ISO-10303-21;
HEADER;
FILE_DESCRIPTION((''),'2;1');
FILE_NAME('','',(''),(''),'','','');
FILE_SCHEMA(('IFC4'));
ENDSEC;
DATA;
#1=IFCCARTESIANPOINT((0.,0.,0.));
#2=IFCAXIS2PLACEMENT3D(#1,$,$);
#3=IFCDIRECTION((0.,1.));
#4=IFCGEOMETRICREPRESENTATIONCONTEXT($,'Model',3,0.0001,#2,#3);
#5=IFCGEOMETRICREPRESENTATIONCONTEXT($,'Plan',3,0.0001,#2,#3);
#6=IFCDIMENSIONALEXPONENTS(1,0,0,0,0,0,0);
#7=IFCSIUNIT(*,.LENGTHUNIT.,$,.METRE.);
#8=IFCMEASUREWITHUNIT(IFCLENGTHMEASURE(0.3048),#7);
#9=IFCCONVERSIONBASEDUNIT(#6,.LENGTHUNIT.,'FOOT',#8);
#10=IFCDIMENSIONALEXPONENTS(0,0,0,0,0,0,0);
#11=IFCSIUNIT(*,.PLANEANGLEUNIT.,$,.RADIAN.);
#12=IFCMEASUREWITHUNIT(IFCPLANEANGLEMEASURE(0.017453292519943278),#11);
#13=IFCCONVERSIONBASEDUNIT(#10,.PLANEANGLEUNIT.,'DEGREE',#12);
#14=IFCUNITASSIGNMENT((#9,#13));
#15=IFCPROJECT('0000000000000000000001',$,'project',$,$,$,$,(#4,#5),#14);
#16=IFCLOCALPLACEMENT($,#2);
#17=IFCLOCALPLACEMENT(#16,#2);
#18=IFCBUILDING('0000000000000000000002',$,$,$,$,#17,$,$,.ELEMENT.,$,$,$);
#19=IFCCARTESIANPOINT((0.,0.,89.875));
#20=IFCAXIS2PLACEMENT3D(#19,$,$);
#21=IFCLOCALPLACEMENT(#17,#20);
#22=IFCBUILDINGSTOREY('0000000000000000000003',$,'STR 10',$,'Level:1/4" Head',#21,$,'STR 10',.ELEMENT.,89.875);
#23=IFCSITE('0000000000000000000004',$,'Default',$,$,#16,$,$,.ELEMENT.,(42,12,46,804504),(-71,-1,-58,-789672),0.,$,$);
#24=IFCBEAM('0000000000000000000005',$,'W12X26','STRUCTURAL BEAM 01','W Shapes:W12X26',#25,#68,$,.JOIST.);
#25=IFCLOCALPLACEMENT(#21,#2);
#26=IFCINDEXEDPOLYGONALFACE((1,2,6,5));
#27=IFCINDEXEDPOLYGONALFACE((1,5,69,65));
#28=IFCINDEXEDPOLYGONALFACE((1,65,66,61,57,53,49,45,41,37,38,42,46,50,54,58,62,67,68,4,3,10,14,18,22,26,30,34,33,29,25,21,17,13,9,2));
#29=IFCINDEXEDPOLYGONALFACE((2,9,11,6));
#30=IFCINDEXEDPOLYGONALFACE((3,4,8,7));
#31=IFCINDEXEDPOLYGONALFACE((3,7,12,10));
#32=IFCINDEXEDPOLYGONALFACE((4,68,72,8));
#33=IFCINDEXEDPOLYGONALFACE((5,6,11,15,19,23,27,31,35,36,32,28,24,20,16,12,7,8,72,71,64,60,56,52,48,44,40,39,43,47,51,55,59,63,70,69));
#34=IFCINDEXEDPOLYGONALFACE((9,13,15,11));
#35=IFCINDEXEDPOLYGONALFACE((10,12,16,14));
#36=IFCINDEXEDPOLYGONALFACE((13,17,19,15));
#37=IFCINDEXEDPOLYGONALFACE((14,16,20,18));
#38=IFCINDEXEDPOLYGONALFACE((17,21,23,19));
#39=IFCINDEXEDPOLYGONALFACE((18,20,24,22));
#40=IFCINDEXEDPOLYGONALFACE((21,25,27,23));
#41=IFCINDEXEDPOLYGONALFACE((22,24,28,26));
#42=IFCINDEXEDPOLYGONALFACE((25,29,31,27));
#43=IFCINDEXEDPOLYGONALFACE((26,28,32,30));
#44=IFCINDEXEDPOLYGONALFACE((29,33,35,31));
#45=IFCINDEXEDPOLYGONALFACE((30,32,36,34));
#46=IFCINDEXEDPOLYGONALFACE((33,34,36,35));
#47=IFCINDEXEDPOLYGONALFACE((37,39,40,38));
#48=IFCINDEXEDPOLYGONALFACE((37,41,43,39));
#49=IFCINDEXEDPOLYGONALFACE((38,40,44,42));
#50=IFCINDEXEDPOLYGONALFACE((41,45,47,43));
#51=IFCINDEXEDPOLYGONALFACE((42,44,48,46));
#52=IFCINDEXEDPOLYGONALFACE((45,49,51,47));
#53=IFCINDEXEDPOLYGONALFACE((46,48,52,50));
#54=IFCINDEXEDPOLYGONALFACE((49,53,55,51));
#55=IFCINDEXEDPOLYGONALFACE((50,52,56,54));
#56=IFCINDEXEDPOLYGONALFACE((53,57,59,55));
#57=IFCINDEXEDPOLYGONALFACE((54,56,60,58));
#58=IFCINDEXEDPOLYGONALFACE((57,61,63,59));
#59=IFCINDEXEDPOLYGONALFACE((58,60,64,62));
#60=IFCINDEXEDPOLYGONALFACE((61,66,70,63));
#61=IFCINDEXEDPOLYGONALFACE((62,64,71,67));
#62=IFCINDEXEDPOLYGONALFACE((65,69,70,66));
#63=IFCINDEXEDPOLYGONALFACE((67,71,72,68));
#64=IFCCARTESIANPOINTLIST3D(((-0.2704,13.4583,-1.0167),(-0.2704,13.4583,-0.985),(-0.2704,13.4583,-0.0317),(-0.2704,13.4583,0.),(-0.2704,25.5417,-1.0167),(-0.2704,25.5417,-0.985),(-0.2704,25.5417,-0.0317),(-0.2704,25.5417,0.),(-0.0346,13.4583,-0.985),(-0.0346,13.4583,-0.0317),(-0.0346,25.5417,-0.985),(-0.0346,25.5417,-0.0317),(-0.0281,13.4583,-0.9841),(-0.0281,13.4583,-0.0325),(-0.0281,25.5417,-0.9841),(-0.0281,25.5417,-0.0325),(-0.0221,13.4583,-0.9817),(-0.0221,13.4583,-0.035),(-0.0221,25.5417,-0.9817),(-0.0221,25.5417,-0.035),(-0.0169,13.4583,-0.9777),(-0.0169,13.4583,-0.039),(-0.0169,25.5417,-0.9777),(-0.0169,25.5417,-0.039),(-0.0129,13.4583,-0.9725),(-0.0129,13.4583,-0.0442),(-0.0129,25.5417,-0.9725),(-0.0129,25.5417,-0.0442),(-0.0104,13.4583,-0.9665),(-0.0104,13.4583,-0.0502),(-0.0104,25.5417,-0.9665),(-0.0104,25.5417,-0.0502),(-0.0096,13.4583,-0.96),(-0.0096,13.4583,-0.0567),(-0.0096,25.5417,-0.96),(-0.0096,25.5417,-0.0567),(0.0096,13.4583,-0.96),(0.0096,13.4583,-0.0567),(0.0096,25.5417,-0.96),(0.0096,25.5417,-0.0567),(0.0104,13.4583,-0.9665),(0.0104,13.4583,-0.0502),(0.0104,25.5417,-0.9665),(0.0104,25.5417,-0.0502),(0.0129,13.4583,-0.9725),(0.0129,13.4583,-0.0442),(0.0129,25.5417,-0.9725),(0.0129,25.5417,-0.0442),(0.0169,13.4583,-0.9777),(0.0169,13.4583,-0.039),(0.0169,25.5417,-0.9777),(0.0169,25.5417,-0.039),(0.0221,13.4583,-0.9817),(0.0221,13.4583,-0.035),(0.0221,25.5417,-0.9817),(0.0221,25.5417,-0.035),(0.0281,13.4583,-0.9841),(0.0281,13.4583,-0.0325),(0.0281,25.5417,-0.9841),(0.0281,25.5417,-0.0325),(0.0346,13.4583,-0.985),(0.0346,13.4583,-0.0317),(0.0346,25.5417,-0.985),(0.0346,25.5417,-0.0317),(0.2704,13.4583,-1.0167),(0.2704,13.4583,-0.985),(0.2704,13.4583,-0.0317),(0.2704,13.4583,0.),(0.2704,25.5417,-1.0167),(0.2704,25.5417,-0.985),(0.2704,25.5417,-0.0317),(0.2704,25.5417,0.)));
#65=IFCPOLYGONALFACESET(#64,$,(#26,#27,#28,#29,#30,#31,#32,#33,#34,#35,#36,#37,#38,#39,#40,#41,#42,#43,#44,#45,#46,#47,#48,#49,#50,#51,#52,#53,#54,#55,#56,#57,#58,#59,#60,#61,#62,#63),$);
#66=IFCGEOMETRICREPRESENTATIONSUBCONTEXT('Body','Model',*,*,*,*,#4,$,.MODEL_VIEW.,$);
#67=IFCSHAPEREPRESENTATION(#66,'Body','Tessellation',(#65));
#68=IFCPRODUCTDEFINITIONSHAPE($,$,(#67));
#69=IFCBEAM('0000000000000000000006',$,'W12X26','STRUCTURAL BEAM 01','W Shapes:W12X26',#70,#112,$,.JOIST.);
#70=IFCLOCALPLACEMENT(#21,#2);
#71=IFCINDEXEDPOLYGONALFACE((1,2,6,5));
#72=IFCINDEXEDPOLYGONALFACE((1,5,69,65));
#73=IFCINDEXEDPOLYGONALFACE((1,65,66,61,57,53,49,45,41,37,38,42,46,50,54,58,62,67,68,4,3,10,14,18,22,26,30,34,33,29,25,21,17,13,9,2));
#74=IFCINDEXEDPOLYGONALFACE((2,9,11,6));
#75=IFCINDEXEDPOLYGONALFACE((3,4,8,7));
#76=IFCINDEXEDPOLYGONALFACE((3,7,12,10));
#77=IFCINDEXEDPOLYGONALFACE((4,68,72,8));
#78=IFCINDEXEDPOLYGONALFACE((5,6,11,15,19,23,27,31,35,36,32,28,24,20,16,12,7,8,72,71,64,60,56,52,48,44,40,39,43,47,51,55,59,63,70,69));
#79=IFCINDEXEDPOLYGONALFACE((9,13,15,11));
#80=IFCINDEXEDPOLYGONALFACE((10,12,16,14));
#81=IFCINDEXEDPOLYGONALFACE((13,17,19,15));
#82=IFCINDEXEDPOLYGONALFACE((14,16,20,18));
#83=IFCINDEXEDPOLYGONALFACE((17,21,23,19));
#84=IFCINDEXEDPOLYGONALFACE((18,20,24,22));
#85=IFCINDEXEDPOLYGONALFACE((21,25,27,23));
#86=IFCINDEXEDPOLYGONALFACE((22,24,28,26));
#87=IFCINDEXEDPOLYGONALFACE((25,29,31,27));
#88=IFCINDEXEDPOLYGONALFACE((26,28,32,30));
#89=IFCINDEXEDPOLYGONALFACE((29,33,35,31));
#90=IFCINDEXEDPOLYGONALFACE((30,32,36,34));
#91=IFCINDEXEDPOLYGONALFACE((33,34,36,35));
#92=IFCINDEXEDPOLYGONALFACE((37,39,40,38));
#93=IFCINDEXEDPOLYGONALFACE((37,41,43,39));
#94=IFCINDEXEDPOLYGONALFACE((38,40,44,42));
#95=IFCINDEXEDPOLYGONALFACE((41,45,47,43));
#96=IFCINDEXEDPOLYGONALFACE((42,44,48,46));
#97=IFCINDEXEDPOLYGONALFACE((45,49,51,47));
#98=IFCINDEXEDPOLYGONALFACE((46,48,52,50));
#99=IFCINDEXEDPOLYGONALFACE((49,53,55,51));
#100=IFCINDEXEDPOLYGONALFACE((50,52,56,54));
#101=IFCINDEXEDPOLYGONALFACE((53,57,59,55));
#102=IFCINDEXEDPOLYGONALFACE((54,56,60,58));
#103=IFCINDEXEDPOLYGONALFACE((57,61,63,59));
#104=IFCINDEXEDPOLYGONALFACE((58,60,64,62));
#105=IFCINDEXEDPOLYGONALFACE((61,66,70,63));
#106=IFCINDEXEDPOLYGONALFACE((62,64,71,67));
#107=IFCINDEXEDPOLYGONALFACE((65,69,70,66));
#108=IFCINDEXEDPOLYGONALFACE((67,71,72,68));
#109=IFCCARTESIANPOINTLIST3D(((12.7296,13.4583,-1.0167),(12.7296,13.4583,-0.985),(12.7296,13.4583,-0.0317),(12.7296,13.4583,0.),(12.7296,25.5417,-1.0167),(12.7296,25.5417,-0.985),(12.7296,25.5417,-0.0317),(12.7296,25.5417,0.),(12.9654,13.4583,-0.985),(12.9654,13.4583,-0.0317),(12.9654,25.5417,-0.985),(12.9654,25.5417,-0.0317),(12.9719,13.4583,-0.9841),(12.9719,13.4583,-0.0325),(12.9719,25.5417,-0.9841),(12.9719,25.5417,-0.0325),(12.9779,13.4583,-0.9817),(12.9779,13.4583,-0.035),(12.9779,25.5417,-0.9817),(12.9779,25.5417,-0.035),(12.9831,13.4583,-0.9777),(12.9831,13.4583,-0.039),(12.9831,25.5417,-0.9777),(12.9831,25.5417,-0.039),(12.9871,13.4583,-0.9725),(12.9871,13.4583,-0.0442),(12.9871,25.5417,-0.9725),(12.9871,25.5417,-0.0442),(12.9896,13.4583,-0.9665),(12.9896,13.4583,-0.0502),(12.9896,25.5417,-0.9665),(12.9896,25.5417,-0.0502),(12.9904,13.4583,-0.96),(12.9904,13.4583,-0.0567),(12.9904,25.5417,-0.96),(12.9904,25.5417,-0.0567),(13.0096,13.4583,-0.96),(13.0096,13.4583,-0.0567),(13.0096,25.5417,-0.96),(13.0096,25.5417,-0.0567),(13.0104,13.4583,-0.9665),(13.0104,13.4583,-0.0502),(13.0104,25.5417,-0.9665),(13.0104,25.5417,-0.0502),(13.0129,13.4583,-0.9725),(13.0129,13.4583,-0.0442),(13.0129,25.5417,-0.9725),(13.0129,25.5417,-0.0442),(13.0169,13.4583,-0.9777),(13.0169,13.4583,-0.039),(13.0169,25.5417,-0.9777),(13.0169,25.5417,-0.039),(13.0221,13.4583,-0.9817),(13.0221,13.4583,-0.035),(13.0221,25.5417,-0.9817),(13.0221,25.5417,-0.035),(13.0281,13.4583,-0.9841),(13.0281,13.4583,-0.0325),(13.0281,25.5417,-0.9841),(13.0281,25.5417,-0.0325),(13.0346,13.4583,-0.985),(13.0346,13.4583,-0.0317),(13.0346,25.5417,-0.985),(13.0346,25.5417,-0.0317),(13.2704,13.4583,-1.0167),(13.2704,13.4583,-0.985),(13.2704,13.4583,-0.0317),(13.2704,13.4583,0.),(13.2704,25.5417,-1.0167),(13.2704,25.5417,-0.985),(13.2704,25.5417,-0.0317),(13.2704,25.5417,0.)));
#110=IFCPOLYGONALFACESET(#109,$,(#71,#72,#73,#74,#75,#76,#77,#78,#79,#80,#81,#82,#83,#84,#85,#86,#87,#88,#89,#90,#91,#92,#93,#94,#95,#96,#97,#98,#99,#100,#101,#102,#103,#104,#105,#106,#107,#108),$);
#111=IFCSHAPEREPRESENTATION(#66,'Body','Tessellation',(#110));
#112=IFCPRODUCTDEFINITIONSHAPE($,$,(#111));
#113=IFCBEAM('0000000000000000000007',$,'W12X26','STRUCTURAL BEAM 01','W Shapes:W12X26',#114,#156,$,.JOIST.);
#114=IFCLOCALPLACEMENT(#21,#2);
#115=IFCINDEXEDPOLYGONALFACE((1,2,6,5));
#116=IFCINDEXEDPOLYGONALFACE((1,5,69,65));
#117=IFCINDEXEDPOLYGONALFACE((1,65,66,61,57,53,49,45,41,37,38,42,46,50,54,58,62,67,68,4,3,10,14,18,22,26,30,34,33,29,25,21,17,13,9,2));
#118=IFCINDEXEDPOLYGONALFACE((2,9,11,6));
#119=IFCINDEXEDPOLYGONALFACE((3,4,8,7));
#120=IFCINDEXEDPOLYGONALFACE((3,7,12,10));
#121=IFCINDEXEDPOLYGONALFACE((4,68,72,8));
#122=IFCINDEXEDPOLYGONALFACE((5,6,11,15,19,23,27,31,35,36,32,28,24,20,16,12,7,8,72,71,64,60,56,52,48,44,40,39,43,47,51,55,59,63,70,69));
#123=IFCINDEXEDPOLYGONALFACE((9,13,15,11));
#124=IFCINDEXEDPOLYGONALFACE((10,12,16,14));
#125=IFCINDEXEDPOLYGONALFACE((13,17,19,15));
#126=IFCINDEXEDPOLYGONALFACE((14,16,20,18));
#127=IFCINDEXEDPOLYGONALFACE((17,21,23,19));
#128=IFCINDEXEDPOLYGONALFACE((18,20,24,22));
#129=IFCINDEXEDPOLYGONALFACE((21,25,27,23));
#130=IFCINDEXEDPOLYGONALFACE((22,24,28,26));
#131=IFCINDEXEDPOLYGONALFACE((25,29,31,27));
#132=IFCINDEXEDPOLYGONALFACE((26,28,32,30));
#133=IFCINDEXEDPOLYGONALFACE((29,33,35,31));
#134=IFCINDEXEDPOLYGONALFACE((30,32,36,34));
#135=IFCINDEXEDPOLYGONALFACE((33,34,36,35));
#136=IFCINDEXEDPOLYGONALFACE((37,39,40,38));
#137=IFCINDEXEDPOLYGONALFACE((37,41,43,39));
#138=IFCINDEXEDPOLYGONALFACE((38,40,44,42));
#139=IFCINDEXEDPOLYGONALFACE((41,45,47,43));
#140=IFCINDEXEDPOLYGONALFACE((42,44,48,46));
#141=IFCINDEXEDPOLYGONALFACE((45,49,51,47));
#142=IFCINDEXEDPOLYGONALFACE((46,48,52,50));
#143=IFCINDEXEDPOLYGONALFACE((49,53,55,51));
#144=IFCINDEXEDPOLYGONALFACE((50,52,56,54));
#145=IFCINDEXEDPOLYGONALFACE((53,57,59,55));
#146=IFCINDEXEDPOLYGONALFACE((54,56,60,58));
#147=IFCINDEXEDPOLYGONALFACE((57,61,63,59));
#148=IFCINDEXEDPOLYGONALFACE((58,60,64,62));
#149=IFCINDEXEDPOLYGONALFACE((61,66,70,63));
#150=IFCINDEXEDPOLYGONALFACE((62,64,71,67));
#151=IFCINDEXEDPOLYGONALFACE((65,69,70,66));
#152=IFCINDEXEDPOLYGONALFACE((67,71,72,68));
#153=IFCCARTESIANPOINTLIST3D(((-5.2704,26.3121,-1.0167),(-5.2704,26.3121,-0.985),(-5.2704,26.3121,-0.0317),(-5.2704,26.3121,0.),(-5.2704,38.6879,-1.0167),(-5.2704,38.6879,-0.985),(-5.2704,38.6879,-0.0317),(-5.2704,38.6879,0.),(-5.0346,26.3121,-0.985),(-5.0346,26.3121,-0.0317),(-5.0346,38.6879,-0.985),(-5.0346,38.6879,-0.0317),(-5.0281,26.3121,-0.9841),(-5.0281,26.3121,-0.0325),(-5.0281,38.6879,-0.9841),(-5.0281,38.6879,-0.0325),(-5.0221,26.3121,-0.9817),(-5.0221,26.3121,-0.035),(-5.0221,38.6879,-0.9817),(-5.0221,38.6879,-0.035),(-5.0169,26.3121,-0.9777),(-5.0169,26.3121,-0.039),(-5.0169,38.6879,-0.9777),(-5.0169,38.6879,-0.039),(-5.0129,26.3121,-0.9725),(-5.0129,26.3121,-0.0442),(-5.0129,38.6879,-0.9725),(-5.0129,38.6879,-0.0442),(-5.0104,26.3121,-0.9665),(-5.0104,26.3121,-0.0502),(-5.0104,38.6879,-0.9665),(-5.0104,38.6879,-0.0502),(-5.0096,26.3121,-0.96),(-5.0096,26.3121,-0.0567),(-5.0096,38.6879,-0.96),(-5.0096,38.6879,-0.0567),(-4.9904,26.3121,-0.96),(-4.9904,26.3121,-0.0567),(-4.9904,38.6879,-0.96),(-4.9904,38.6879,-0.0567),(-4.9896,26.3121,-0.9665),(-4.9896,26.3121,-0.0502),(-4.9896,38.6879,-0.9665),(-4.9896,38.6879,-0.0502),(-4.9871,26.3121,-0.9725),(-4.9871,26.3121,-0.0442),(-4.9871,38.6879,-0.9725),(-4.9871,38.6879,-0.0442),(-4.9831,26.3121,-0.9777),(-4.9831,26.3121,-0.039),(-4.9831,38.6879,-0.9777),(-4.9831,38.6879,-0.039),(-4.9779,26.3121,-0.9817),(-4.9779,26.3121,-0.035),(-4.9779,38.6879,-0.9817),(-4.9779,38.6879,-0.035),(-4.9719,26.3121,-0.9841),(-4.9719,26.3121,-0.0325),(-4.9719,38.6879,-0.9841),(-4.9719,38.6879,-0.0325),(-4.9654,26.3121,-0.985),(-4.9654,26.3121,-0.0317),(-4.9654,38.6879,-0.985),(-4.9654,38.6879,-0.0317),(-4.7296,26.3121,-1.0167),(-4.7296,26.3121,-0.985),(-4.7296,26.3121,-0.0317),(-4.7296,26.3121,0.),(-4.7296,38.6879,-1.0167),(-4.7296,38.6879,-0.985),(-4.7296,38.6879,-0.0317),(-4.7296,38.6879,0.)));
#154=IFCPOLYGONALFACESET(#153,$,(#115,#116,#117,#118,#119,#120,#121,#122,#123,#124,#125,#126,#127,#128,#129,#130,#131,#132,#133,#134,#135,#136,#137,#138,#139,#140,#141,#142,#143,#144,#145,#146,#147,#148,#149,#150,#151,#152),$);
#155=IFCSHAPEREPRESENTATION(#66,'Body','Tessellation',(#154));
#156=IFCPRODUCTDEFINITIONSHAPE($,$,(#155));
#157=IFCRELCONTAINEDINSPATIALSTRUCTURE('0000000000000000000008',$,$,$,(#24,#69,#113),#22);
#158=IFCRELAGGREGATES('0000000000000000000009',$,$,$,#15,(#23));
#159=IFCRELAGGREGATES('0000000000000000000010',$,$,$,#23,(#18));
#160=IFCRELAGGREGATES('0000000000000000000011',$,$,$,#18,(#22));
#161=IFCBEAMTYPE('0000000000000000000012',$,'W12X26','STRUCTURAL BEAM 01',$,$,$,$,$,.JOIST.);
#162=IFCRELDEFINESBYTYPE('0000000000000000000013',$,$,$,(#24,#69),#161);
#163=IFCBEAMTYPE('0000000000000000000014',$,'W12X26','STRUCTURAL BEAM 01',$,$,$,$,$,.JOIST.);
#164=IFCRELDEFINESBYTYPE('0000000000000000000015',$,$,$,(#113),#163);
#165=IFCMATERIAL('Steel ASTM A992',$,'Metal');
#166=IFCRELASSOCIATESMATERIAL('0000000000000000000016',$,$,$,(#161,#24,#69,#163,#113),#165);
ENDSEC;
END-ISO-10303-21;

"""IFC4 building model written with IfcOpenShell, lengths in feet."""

from ifc_helpers import new_model, entity, si_unit, converted_unit, direction, frame, origin, place, context, subcontext, project, spatial, line, arc, indexed_curve, outline, extrude, source, transform, mapped, material, type_object, type_shapes, element, save


model = new_model("IFC4")

# Units and contexts
model_context = context("Model", 3, precision=0.0001, world=origin(), true_north=direction((0.0, 1.0)))
plan_context = context("Plan", 3, precision=0.0001, world=origin(), true_north=direction((0.0, 1.0)))
body_context = subcontext(model_context, "Body", "Model", "MODEL_VIEW")
ifc_project = project(units=[converted_unit("LENGTHUNIT", "FOOT", entity("IfcLengthMeasure", 0.3048), si_unit("LENGTHUNIT", "METRE"), dimensions=[1, 0, 0, 0, 0, 0, 0]), converted_unit("PLANEANGLEUNIT", "DEGREE", entity("IfcPlaneAngleMeasure", 0.017453292519943278), si_unit("PLANEANGLEUNIT", "RADIAN"), dimensions=[0, 0, 0, 0, 0, 0, 0])], contexts=[model_context, plan_context])

# Site, building, storey
site_placement = place(None, origin())
site = spatial("IfcSite", under=ifc_project, at=site_placement, Name="Default", CompositionType="ELEMENT", RefLatitude=(42, 12, 46, 804504), RefLongitude=(-71, -1, -58, -789672), RefElevation=0.0)
building_placement = place(site_placement, origin())
building = spatial("IfcBuilding", under=site, at=building_placement, CompositionType="ELEMENT")
storey_placement = place(building_placement, frame((0.0, 0.0, 89.875)))
storey = spatial("IfcBuildingStorey", under=building, at=storey_placement, Name="STR 10", ObjectType="Level:1/4\" Head", LongName="STR 10", CompositionType="ELEMENT", Elevation=89.875)

# Beams
ifc_material = material(Name="Steel ASTM A992", Category="Metal")
beam_type_1 = type_object("IfcBeamType", Name="W12X26", Description="STRUCTURAL BEAM 01", PredefinedType="JOIST", material=ifc_material)
shared_shape_1 = source(origin(), body_context, "Body", "SweptSolid", [
    extrude(outline(indexed_curve([(-0.2704, -0.4767), (-0.2704, -0.5083), (0.2704, -0.5083), (0.2704, -0.4767), (0.0346, -0.4767), (0.0169, -0.4693), (0.0096, -0.4517), (0.0096, 0.4517), (0.0169, 0.4693), (0.0346, 0.4767), (0.2704, 0.4767), (0.2704, 0.5083), (-0.2704, 0.5083), (-0.2704, 0.4767), (-0.0346, 0.4767), (-0.0169, 0.4693), (-0.0096, 0.4517), (-0.0096, -0.4517), (-0.0169, -0.4693), (-0.0346, -0.4767)], segments=[line(1, 2, 3, 4, 5), arc(5, 6, 7), line(7, 8), arc(8, 9, 10), line(10, 11, 12, 13, 14, 15), arc(15, 16, 17), line(17, 18), arc(18, 19, 20), line(20, 1)], self_intersect=False)), frame((-6.2267, 0.0, 0.0), z_axis=(-1.0, 0.0, 0.0), x_axis=(0.0, -1.0, 0.0)), (0.0, 0.0, -1.0), 12.0833),
])
type_shapes(beam_type_1, [shared_shape_1])
for number, where, z_axis, x_axis, name in (
    (1, (0.0, 19.685, -0.5083), (0.0, 0.0, 1.0), (0.0, 1.0, 0.0), "W12X26"),
    (2, (13.0, 19.685, -0.5083), (0.0, 0.0, 1.0), (0.0, 1.0, 0.0), "W12X26"),
):
    element("IfcBeam", number, at=place(storey_placement, frame(where, z_axis=z_axis, x_axis=x_axis)), inside=storey, type_object=beam_type_1, material=ifc_material, Name=name, Description="STRUCTURAL BEAM 01", ObjectType="W Shapes:W12X26", PredefinedType="JOIST", context=body_context, shape_type="MappedRepresentation", body=[
        mapped(shared_shape_1, transform((0.0, 0.0, 0.0), scale=1.0)),
    ])
beam_type_2 = type_object("IfcBeamType", Name="W12X26", Description="STRUCTURAL BEAM 01", PredefinedType="JOIST", material=ifc_material)
shared_shape_2 = source(origin(), body_context, "Body", "SweptSolid", [
    extrude(outline(indexed_curve([(-0.2704, -0.4767), (-0.2704, -0.5083), (0.2704, -0.5083), (0.2704, -0.4767), (0.0346, -0.4767), (0.0169, -0.4693), (0.0096, -0.4517), (0.0096, 0.4517), (0.0169, 0.4693), (0.0346, 0.4767), (0.2704, 0.4767), (0.2704, 0.5083), (-0.2704, 0.5083), (-0.2704, 0.4767), (-0.0346, 0.4767), (-0.0169, 0.4693), (-0.0096, 0.4517), (-0.0096, -0.4517), (-0.0169, -0.4693), (-0.0346, -0.4767)], segments=[line(1, 2, 3, 4, 5), arc(5, 6, 7), line(7, 8), arc(8, 9, 10), line(10, 11, 12, 13, 14, 15), arc(15, 16, 17), line(17, 18), arc(18, 19, 20), line(20, 1)], self_intersect=False)), frame((-6.1879, 0.0, 0.0), z_axis=(-1.0, 0.0, 0.0), x_axis=(0.0, -1.0, 0.0)), (0.0, 0.0, -1.0), 12.3758),
])
type_shapes(beam_type_2, [shared_shape_2])
for number, where, z_axis, x_axis, name in (
    (3, (-5.0, 32.5, -0.5083), (0.0, 0.0, 1.0), (0.0, 1.0, 0.0), "W12X26"),
):
    element("IfcBeam", number, at=place(storey_placement, frame(where, z_axis=z_axis, x_axis=x_axis)), inside=storey, type_object=beam_type_2, material=ifc_material, Name=name, Description="STRUCTURAL BEAM 01", ObjectType="W Shapes:W12X26", PredefinedType="JOIST", context=body_context, shape_type="MappedRepresentation", body=[
        mapped(shared_shape_2, transform((0.0, 0.0, 0.0), scale=1.0)),
    ])

save(model, "model.ifc")
